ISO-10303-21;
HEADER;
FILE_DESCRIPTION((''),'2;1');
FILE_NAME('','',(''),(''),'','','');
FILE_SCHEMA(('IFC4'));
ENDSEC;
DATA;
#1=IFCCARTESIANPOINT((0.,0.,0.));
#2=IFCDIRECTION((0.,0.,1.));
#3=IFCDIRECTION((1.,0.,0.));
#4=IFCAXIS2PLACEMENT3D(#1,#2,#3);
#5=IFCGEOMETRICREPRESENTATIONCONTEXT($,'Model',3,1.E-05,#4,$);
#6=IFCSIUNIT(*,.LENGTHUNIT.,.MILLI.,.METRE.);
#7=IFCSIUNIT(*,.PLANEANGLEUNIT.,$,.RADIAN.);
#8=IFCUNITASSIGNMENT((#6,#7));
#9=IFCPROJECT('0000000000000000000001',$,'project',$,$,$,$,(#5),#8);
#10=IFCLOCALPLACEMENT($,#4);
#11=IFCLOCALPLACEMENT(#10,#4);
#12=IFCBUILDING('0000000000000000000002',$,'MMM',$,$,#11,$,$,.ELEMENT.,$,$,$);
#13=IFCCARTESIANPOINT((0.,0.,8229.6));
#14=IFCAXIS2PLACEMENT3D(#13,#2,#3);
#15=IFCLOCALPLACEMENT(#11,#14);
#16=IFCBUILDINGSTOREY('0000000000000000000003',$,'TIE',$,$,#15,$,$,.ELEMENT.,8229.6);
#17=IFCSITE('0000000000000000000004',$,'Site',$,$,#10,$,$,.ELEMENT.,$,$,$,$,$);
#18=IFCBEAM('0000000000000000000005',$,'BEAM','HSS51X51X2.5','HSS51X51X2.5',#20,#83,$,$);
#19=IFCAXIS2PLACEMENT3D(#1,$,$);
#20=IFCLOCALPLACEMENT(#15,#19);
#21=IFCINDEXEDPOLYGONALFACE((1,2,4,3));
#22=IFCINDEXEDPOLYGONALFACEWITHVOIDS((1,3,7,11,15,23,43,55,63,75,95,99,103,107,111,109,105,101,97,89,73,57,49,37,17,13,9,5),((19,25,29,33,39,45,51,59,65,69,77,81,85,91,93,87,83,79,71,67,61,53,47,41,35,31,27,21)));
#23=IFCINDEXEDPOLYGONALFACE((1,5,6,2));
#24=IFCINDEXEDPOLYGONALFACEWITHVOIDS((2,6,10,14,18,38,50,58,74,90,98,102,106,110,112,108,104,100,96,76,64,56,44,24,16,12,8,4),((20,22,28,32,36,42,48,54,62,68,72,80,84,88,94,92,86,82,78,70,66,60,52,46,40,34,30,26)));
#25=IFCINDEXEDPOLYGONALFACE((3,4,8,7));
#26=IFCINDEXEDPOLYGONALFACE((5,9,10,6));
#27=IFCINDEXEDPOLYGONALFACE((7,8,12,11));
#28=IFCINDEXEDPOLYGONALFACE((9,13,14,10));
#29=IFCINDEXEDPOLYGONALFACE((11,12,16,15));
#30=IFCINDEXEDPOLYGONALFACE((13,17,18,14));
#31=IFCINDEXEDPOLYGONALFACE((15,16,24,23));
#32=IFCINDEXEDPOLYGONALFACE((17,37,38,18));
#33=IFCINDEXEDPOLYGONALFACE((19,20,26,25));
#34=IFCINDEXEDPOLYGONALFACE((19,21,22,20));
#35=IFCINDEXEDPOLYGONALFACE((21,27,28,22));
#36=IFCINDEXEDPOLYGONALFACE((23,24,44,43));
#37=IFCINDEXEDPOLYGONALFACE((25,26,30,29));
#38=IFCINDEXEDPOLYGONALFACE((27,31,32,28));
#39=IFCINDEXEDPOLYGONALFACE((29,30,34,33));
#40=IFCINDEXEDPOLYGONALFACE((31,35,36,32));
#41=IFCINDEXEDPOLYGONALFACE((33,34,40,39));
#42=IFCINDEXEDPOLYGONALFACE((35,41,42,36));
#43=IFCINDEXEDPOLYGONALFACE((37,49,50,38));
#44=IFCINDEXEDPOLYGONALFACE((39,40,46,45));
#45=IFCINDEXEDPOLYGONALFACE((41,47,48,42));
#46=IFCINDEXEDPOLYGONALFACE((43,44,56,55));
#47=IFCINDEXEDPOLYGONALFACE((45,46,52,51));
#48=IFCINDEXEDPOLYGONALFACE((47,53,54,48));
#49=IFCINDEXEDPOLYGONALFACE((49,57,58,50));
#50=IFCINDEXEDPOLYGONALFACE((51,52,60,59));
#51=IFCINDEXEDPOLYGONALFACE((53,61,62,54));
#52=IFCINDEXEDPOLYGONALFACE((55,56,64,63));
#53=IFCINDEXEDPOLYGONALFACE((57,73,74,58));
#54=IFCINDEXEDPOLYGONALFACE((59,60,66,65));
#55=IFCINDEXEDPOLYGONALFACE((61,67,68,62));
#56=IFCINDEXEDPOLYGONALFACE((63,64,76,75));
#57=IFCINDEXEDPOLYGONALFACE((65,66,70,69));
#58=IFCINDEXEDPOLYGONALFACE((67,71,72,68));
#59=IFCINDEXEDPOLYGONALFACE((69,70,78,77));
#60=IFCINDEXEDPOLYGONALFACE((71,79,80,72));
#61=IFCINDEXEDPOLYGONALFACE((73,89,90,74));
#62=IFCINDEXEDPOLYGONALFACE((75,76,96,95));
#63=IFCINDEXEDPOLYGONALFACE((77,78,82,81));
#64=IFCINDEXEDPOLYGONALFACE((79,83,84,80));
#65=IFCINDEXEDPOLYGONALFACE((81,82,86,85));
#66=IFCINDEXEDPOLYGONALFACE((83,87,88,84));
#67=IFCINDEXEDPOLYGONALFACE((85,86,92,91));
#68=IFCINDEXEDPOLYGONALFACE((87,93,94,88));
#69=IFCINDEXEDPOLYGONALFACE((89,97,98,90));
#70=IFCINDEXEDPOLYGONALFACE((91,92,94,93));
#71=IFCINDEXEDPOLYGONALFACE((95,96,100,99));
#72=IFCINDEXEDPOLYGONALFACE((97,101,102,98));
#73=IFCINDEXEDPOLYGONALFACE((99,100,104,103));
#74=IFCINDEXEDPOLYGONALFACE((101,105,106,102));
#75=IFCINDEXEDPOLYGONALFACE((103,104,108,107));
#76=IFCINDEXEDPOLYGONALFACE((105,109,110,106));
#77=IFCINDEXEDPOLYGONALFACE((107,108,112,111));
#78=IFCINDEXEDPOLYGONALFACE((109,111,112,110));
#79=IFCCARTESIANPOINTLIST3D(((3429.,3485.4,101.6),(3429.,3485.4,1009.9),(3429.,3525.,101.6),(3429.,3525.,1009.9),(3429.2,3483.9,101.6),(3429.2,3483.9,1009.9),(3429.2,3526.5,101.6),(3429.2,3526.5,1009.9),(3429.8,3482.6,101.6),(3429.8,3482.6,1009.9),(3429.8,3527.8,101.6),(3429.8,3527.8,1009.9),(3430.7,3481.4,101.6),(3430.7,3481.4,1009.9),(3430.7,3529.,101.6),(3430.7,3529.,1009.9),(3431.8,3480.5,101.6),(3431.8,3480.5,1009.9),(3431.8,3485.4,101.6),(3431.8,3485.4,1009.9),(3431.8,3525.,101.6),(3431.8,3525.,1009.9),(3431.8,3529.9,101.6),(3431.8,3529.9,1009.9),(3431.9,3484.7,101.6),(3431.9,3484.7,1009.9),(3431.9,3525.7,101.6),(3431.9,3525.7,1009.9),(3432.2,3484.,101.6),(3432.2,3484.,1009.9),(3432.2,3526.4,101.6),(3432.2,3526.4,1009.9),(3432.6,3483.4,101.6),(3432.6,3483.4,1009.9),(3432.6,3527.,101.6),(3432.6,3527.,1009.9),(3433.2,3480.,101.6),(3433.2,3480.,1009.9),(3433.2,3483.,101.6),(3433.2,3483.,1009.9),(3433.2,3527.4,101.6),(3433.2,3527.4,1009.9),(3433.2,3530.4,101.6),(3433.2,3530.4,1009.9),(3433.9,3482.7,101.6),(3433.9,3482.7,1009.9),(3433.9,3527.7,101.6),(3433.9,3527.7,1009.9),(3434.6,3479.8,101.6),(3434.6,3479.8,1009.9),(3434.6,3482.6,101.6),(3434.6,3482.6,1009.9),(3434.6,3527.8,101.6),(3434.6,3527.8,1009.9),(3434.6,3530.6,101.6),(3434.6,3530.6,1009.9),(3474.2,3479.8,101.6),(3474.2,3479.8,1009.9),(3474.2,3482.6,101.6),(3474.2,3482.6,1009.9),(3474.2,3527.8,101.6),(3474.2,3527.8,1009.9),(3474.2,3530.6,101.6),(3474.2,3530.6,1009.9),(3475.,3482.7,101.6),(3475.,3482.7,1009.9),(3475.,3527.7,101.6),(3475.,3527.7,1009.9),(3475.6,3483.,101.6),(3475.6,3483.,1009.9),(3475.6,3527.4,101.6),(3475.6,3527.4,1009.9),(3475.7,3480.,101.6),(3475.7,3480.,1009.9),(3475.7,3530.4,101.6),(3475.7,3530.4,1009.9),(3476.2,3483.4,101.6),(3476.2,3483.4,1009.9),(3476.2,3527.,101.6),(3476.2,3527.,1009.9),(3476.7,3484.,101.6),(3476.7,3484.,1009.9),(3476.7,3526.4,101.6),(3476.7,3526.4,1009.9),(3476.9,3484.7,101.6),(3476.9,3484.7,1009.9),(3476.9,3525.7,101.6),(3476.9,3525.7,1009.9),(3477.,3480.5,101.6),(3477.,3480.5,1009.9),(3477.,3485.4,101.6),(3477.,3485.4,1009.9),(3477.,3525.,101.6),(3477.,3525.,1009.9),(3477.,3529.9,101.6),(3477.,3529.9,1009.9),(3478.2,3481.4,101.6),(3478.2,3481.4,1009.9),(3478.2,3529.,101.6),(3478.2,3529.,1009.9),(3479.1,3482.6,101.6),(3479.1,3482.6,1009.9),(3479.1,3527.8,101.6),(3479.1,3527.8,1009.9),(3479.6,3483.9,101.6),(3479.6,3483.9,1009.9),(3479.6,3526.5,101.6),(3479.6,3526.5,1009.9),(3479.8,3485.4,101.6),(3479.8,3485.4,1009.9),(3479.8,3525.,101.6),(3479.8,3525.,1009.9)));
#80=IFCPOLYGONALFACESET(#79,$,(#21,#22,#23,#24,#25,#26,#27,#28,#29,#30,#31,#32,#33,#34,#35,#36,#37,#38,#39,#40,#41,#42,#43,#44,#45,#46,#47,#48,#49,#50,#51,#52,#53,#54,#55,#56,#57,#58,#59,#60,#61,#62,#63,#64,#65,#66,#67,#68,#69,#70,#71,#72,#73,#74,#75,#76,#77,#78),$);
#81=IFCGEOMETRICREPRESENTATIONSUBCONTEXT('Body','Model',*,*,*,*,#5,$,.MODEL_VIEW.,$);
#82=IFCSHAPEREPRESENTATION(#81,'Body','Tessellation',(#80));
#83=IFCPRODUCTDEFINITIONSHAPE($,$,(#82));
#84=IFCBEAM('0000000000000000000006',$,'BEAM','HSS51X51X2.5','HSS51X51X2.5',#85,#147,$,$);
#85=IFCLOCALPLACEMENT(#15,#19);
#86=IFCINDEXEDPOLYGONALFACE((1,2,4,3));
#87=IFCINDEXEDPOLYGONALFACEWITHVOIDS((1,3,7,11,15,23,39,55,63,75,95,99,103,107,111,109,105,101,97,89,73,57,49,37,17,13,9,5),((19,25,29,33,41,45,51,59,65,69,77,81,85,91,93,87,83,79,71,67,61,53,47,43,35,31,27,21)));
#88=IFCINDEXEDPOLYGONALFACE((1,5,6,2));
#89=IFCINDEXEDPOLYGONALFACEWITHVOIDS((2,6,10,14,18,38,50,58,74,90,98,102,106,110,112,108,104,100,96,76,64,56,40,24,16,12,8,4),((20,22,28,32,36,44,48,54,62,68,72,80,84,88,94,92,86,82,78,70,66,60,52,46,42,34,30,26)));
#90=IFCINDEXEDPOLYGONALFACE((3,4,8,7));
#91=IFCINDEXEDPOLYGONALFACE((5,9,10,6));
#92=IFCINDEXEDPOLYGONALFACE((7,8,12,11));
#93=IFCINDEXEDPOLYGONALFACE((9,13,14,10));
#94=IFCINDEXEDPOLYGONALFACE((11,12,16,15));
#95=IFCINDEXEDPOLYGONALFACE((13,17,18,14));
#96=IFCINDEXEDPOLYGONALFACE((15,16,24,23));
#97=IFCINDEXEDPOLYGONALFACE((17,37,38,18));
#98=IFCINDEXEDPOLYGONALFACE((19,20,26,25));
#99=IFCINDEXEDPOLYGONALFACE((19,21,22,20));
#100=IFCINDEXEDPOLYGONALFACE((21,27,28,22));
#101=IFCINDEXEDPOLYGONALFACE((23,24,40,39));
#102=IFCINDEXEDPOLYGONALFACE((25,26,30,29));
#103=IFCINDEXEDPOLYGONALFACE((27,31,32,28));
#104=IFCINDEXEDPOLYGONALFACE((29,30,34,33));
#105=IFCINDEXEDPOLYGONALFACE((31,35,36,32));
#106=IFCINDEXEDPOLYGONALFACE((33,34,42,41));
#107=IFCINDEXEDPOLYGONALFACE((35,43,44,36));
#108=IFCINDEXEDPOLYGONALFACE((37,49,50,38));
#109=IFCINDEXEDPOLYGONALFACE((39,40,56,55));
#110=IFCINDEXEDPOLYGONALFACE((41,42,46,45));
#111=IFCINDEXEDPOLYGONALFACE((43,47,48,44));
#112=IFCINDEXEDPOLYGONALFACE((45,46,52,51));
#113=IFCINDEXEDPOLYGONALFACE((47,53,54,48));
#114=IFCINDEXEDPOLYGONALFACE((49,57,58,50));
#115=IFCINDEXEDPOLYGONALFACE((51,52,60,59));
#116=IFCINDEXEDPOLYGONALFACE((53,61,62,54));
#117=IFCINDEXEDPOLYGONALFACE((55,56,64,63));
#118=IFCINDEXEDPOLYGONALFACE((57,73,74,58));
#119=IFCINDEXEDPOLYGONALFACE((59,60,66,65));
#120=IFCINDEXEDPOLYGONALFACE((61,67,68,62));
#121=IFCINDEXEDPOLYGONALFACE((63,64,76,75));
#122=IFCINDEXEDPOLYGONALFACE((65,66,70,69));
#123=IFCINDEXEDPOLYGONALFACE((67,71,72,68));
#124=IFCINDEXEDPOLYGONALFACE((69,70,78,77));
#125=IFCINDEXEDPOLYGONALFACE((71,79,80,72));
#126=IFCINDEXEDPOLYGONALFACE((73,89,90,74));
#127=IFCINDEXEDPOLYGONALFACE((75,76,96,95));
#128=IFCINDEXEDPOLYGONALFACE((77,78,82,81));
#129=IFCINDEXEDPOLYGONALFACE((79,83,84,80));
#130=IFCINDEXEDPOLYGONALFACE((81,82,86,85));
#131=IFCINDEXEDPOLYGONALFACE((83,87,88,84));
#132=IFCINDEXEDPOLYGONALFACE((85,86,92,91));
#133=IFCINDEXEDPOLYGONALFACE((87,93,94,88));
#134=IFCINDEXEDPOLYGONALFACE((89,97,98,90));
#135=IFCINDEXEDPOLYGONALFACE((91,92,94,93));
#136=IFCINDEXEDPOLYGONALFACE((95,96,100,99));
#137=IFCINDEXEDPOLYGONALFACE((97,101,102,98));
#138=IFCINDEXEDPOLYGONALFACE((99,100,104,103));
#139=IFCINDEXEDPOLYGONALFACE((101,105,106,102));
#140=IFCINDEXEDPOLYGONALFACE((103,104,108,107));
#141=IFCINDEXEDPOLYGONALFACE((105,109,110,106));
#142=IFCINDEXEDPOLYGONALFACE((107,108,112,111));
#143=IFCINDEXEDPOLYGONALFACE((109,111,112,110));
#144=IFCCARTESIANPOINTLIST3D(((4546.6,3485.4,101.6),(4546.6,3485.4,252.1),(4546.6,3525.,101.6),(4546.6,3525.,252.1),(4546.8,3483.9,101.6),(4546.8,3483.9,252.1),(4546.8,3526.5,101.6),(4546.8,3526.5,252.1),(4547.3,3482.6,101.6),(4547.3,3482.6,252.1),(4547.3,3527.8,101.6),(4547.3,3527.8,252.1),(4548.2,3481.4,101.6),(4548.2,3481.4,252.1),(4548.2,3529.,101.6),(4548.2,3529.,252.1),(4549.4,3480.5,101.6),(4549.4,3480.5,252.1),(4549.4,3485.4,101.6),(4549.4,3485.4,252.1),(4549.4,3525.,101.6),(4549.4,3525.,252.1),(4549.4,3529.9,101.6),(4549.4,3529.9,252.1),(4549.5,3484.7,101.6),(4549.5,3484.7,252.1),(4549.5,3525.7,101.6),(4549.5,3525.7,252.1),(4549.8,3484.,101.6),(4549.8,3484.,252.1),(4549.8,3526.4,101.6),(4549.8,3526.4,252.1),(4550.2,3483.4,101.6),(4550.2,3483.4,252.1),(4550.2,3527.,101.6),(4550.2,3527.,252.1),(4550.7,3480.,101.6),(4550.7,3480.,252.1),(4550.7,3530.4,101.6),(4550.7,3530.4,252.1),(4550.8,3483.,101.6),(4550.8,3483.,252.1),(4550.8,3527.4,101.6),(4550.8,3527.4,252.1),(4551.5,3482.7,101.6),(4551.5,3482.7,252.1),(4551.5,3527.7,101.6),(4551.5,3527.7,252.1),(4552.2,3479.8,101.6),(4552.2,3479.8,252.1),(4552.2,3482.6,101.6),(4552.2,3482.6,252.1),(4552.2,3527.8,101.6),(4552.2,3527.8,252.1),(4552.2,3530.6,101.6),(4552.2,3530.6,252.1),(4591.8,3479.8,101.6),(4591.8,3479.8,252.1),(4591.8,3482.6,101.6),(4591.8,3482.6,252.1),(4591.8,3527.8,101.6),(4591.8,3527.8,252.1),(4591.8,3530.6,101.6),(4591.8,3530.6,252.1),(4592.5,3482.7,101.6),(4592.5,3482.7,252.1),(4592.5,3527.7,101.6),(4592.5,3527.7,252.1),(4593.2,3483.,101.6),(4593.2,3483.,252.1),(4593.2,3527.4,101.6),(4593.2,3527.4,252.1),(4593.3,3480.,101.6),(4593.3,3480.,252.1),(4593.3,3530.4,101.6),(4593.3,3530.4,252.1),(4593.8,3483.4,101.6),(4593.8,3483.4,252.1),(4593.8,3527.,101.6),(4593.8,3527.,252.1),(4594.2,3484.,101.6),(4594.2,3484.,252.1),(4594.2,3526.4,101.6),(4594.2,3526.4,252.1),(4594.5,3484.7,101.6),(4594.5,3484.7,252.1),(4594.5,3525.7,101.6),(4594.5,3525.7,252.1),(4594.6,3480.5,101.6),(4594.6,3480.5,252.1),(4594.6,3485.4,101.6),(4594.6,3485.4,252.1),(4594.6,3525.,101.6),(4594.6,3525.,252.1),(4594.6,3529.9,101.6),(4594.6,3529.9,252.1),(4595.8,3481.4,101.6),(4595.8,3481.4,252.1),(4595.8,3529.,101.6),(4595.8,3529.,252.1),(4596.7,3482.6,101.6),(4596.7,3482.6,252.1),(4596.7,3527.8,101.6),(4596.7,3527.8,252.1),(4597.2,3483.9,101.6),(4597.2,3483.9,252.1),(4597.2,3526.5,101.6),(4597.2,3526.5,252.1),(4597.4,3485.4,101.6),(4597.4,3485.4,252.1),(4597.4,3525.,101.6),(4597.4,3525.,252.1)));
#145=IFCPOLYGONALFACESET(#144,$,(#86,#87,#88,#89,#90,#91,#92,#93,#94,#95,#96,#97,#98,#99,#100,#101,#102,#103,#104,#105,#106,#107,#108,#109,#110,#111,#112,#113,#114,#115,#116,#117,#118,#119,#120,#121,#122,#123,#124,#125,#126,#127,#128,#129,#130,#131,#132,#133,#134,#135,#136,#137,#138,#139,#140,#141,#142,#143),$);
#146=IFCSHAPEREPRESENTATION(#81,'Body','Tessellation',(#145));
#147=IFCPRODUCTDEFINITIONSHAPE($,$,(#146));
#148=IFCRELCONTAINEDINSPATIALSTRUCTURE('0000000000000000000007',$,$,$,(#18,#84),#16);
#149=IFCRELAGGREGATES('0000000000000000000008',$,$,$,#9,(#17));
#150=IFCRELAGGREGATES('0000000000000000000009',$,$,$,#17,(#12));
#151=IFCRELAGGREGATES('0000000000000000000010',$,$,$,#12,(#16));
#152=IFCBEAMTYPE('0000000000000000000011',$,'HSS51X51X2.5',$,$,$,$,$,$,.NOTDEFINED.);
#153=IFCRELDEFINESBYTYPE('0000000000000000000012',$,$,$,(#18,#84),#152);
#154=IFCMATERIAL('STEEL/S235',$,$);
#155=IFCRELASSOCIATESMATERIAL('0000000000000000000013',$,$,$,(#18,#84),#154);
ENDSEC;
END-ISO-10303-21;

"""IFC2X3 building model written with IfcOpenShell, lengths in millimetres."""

from ifc_helpers import new_model, si_unit, frame, origin_with_axes, origin_2d_with_axis, place, context, subcontext, project, spatial, hollow_rectangle, extrude, material, type_object, element, save


model = new_model("IFC2X3")

# Units and contexts
model_context = context("Model", 3, precision=1e-05, world=origin_with_axes())
body_context = subcontext(model_context, "Body", "Model", "MODEL_VIEW")
ifc_project = project(units=[si_unit("LENGTHUNIT", "METRE", prefix="MILLI"), si_unit("PLANEANGLEUNIT", "RADIAN")], contexts=[model_context])

# Site, building, storey
site_placement = place(None, origin_with_axes())
site = spatial("IfcSite", under=ifc_project, at=site_placement, Name="Site", CompositionType="ELEMENT")
building_placement = place(site_placement, origin_with_axes())
building = spatial("IfcBuilding", under=site, at=building_placement, Name="MMM", CompositionType="ELEMENT")
storey_placement = place(building_placement, frame((0.0, 0.0, 8229.6), z_axis=(0.0, 0.0, 1.0), x_axis=(1.0, 0.0, 0.0)))
storey = spatial("IfcBuildingStorey", under=building, at=storey_placement, Name="TIE", CompositionType="ELEMENT", Elevation=8229.6)

# Beams
ifc_material = material(Name="STEEL/S235")
beam_type_1 = type_object("IfcBeamType", Name="HSS51X51X2.5", PredefinedType="NOTDEFINED")
beam_1_placement = place(storey_placement, frame((3454.4, 3505.2, 1009.9), z_axis=(-1.0, 0.0, 0.0), x_axis=(0.0, 0.0, -1.0)))
element("IfcBeam", 1, at=beam_1_placement, inside=storey, type_object=beam_type_1, material=ifc_material, Name="BEAM", Description="HSS51X51X2.5", ObjectType="HSS51X51X2.5", context=body_context, shape_type="SweptSolid", body=[
    extrude(hollow_rectangle(XDim=50.8, YDim=50.8, WallThickness=2.8, InnerFilletRadius=2.8, OuterFilletRadius=5.6, at=origin_2d_with_axis()), frame((908.3, 0.0, 0.0), z_axis=(-1.0, 0.0, 0.0), x_axis=(0.0, -1.0, 0.0)), (0.0, 0.0, 1.0), 908.3),
])
beam_2_placement = place(storey_placement, frame((4572.0, 3505.2, 252.1), z_axis=(-1.0, 0.0, 0.0), x_axis=(0.0, 0.0, -1.0)))
element("IfcBeam", 2, at=beam_2_placement, inside=storey, type_object=beam_type_1, material=ifc_material, Name="BEAM", Description="HSS51X51X2.5", ObjectType="HSS51X51X2.5", context=body_context, shape_type="SweptSolid", body=[
    extrude(hollow_rectangle(XDim=50.8, YDim=50.8, WallThickness=2.8, InnerFilletRadius=2.8, OuterFilletRadius=5.6, at=origin_2d_with_axis()), frame((150.5, 0.0, 0.0), z_axis=(-1.0, 0.0, 0.0), x_axis=(0.0, -1.0, 0.0)), (0.0, 0.0, 1.0), 150.5),
])

save(model, "model.ifc")
